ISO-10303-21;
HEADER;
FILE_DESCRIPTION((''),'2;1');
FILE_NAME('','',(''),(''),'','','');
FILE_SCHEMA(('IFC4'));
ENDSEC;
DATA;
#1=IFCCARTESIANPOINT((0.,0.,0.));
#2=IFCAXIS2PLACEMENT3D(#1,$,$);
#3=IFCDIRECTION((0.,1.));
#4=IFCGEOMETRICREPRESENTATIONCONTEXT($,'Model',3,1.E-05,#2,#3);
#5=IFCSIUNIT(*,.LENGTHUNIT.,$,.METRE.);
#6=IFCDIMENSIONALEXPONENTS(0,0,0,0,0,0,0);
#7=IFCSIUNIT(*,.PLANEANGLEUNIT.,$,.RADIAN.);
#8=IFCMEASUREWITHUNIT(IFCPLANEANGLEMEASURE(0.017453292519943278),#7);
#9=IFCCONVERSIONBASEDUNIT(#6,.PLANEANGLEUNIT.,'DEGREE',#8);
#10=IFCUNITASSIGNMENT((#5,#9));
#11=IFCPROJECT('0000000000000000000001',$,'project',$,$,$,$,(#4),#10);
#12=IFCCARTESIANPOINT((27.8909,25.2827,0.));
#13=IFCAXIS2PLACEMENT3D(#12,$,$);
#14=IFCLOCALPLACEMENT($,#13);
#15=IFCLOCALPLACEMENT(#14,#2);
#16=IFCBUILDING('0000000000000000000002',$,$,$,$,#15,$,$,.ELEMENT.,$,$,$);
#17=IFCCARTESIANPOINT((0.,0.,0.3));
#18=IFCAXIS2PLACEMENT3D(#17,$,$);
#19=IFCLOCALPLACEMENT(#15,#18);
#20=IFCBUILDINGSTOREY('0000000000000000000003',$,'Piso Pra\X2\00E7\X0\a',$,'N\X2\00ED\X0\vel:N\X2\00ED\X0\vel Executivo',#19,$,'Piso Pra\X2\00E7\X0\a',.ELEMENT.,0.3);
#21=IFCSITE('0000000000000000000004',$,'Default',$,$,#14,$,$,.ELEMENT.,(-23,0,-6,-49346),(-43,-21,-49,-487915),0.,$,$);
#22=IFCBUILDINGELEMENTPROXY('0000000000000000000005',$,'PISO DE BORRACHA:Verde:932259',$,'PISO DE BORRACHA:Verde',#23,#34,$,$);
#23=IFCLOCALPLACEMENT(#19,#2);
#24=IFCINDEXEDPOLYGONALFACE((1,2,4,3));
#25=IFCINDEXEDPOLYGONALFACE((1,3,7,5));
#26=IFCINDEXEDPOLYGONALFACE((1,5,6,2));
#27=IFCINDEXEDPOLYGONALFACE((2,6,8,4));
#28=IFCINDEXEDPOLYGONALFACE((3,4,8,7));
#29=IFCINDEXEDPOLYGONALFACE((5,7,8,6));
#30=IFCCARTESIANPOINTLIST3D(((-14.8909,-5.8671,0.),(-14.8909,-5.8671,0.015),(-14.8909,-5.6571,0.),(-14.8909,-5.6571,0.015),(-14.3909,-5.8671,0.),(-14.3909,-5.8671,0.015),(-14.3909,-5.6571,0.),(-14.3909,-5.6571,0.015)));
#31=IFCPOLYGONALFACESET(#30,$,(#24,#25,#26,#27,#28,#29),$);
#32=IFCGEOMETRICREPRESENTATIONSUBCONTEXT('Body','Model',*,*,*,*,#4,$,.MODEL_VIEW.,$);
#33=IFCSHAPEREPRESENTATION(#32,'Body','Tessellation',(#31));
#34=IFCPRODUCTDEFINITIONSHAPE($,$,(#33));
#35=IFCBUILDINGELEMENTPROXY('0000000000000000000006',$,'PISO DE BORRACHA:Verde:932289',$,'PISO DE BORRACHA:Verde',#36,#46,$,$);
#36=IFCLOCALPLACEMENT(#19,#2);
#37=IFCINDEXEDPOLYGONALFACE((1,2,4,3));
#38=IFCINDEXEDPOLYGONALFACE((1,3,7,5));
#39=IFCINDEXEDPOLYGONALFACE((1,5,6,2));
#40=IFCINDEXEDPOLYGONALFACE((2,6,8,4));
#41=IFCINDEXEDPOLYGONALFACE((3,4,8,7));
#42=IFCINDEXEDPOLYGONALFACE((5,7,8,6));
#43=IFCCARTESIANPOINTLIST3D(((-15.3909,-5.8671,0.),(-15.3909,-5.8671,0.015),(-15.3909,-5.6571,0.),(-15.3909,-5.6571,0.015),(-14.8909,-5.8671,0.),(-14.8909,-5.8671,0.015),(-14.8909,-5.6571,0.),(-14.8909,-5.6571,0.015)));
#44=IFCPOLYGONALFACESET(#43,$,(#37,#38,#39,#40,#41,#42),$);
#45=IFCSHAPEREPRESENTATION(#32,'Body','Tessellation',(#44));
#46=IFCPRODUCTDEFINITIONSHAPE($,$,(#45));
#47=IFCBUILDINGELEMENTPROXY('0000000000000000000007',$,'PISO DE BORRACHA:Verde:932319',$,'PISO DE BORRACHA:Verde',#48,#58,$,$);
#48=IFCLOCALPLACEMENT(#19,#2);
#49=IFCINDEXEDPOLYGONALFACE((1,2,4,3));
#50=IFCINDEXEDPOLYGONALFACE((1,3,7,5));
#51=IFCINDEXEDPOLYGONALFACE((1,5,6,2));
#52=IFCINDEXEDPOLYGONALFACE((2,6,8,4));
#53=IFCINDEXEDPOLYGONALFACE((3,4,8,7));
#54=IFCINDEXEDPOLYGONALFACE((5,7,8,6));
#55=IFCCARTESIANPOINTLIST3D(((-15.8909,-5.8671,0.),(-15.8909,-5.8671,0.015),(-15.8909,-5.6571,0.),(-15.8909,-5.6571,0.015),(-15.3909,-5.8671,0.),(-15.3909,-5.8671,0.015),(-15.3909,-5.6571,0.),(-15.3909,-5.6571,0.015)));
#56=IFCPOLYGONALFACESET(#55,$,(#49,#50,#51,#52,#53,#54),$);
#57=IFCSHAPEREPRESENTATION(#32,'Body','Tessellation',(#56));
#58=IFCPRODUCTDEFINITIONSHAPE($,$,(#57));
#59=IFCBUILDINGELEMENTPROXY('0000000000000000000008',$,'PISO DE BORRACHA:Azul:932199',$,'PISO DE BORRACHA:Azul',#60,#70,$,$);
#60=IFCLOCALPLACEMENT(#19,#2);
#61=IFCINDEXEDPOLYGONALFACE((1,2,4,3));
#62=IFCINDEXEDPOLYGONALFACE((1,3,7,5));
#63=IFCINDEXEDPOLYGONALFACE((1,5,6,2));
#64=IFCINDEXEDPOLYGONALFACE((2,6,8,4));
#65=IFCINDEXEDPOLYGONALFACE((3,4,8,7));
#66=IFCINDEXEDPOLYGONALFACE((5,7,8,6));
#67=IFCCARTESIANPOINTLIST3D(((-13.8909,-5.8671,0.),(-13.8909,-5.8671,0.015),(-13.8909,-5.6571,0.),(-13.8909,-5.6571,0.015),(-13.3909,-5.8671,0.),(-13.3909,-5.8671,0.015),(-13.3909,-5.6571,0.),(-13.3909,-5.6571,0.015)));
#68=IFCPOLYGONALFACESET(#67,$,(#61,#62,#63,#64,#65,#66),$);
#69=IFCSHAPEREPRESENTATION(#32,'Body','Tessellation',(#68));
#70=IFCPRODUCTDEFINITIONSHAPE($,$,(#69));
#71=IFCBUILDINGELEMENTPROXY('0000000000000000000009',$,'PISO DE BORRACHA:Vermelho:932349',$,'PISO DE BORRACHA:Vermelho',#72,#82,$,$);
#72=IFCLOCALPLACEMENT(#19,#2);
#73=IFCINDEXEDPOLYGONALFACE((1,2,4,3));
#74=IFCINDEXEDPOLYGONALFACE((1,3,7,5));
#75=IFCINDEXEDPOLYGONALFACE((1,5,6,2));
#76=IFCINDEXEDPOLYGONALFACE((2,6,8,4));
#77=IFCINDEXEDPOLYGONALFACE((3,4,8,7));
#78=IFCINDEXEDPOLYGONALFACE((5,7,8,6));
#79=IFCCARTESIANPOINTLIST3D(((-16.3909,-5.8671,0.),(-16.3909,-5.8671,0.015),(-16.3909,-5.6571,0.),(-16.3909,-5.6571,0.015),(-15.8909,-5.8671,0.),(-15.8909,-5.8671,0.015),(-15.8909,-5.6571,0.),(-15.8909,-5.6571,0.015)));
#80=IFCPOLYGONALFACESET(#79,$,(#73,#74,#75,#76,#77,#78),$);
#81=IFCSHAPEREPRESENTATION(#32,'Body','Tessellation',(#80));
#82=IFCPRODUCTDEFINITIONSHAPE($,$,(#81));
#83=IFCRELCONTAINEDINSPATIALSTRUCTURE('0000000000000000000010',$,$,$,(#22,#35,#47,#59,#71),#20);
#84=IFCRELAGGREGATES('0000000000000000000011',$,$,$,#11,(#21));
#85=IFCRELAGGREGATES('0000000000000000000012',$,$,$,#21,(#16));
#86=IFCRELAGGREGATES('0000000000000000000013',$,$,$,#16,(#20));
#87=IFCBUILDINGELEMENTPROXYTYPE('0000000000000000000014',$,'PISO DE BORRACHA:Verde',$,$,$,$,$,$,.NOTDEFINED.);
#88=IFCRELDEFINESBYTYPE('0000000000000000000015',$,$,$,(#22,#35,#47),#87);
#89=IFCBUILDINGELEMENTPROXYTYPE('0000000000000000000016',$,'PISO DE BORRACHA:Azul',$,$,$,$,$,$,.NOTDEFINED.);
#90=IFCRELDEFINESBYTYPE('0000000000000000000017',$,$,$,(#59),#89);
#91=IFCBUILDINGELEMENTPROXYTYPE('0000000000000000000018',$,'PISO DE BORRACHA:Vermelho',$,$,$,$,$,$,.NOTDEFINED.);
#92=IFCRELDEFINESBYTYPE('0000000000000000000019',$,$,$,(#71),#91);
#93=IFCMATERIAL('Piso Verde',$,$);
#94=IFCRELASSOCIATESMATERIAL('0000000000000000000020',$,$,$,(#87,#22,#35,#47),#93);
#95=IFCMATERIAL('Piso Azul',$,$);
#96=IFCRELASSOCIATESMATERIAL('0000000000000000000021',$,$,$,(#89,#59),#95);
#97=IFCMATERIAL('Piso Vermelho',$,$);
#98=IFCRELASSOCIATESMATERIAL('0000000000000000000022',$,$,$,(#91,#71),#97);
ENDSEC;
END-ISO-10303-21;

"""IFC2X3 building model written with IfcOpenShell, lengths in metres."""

from ifc_helpers import new_model, entity, si_unit, converted_unit, direction, frame, frame_2d, origin, place, context, subcontext, project, spatial, rectangle, extrude, source, transform, mapped, material, type_object, type_shapes, element, save


model = new_model("IFC2X3")

# Units and contexts
model_context = context("Model", 3, precision=1e-05, world=origin(), true_north=direction((0.0, 1.0)))
body_context = subcontext(model_context, "Body", "Model", "MODEL_VIEW")
ifc_project = project(units=[si_unit("LENGTHUNIT", "METRE"), converted_unit("PLANEANGLEUNIT", "DEGREE", entity("IfcPlaneAngleMeasure", 0.017453292519943278), si_unit("PLANEANGLEUNIT", "RADIAN"), dimensions=[0, 0, 0, 0, 0, 0, 0])], contexts=[model_context])

# Site, building, storey
site_placement = place(None, frame((27.8909, 25.2827, 0.0)))
site = spatial("IfcSite", under=ifc_project, at=site_placement, Name="Default", CompositionType="ELEMENT", RefLatitude=(-23, 0, -6, -49346), RefLongitude=(-43, -21, -49, -487915), RefElevation=0.0)
building_placement = place(site_placement, origin())
building = spatial("IfcBuilding", under=site, at=building_placement, CompositionType="ELEMENT")
storey_placement = place(building_placement, frame((0.0, 0.0, 0.3)))
storey = spatial("IfcBuildingStorey", under=building, at=storey_placement, Name="Piso Praça", ObjectType="Nível:Nível Executivo", LongName="Piso Praça", CompositionType="ELEMENT", Elevation=0.3)

# Building element proxies
ifc_material_1 = material(Name="Piso Verde")
ifc_material_2 = material(Name="Piso Vermelho")
building_element_proxy_type_1 = type_object("IfcBuildingElementProxyType", Name="PISO DE BORRACHA:Verde", PredefinedType="NOTDEFINED", material=ifc_material_1)
shared_shape_1 = source(origin(), body_context, "Body", "SweptSolid", [
    extrude(rectangle(XDim=0.21, YDim=0.5, at=frame_2d((0.0, 0.0), x_axis=(1.0, 0.0))), frame((0.105, 0.25, 0.0), z_axis=(0.0, 0.0, 1.0), x_axis=(-1.0, 0.0, 0.0)), (0.0, 0.0, 1.0), 0.015),
])
type_shapes(building_element_proxy_type_1, [shared_shape_1])
for number, where, z_axis, x_axis, name in (
    (1, (-14.8909, -5.6571, 0.0), (0.0, 0.0, 1.0), (0.0, -1.0, 0.0), "PISO DE BORRACHA:Verde:932259"),
    (2, (-15.3909, -5.6571, 0.0), (0.0, 0.0, 1.0), (0.0, -1.0, 0.0), "PISO DE BORRACHA:Verde:932289"),
    (3, (-15.8909, -5.6571, 0.0), (0.0, 0.0, 1.0), (0.0, -1.0, 0.0), "PISO DE BORRACHA:Verde:932319"),
):
    element("IfcBuildingElementProxy", number, at=place(storey_placement, frame(where, z_axis=z_axis, x_axis=x_axis)), inside=storey, type_object=building_element_proxy_type_1, material=ifc_material_1, Name=name, ObjectType="PISO DE BORRACHA:Verde", context=body_context, shape_type="MappedRepresentation", body=[
        mapped(shared_shape_1, transform((0.0, 0.0, 0.0), scale=1.0)),
    ])
ifc_material_3 = material(Name="Piso Azul")
building_element_proxy_type_2 = type_object("IfcBuildingElementProxyType", Name="PISO DE BORRACHA:Azul", PredefinedType="NOTDEFINED", material=ifc_material_3)
shared_shape_2 = source(origin(), body_context, "Body", "SweptSolid", [
    extrude(rectangle(XDim=0.21, YDim=0.5, at=frame_2d((0.0, 0.0), x_axis=(1.0, 0.0))), frame((0.105, 0.25, 0.0), z_axis=(0.0, 0.0, 1.0), x_axis=(-1.0, 0.0, 0.0)), (0.0, 0.0, 1.0), 0.015),
])
type_shapes(building_element_proxy_type_2, [shared_shape_2])
proxy_1_placement = place(storey_placement, frame((-13.8909, -5.6571, 0.0), z_axis=(0.0, 0.0, 1.0), x_axis=(0.0, -1.0, 0.0)))
element("IfcBuildingElementProxy", 4, at=proxy_1_placement, inside=storey, type_object=building_element_proxy_type_2, material=ifc_material_3, Name="PISO DE BORRACHA:Azul:932199", ObjectType="PISO DE BORRACHA:Azul", context=body_context, shape_type="MappedRepresentation", body=[
    mapped(shared_shape_2, transform((0.0, 0.0, 0.0), scale=1.0)),
])
building_element_proxy_type_3 = type_object("IfcBuildingElementProxyType", Name="PISO DE BORRACHA:Vermelho", PredefinedType="NOTDEFINED", material=ifc_material_2)
shared_shape_3 = source(origin(), body_context, "Body", "SweptSolid", [
    extrude(rectangle(XDim=0.21, YDim=0.5, at=frame_2d((0.0, 0.0), x_axis=(1.0, 0.0))), frame((0.105, 0.25, 0.0), z_axis=(0.0, 0.0, 1.0), x_axis=(-1.0, 0.0, 0.0)), (0.0, 0.0, 1.0), 0.015),
])
type_shapes(building_element_proxy_type_3, [shared_shape_3])
proxy_2_placement = place(storey_placement, frame((-16.3909, -5.6571, 0.0), z_axis=(0.0, 0.0, 1.0), x_axis=(0.0, -1.0, 0.0)))
element("IfcBuildingElementProxy", 5, at=proxy_2_placement, inside=storey, type_object=building_element_proxy_type_3, material=ifc_material_2, Name="PISO DE BORRACHA:Vermelho:932349", ObjectType="PISO DE BORRACHA:Vermelho", context=body_context, shape_type="MappedRepresentation", body=[
    mapped(shared_shape_3, transform((0.0, 0.0, 0.0), scale=1.0)),
])

save(model, "model.ifc")
